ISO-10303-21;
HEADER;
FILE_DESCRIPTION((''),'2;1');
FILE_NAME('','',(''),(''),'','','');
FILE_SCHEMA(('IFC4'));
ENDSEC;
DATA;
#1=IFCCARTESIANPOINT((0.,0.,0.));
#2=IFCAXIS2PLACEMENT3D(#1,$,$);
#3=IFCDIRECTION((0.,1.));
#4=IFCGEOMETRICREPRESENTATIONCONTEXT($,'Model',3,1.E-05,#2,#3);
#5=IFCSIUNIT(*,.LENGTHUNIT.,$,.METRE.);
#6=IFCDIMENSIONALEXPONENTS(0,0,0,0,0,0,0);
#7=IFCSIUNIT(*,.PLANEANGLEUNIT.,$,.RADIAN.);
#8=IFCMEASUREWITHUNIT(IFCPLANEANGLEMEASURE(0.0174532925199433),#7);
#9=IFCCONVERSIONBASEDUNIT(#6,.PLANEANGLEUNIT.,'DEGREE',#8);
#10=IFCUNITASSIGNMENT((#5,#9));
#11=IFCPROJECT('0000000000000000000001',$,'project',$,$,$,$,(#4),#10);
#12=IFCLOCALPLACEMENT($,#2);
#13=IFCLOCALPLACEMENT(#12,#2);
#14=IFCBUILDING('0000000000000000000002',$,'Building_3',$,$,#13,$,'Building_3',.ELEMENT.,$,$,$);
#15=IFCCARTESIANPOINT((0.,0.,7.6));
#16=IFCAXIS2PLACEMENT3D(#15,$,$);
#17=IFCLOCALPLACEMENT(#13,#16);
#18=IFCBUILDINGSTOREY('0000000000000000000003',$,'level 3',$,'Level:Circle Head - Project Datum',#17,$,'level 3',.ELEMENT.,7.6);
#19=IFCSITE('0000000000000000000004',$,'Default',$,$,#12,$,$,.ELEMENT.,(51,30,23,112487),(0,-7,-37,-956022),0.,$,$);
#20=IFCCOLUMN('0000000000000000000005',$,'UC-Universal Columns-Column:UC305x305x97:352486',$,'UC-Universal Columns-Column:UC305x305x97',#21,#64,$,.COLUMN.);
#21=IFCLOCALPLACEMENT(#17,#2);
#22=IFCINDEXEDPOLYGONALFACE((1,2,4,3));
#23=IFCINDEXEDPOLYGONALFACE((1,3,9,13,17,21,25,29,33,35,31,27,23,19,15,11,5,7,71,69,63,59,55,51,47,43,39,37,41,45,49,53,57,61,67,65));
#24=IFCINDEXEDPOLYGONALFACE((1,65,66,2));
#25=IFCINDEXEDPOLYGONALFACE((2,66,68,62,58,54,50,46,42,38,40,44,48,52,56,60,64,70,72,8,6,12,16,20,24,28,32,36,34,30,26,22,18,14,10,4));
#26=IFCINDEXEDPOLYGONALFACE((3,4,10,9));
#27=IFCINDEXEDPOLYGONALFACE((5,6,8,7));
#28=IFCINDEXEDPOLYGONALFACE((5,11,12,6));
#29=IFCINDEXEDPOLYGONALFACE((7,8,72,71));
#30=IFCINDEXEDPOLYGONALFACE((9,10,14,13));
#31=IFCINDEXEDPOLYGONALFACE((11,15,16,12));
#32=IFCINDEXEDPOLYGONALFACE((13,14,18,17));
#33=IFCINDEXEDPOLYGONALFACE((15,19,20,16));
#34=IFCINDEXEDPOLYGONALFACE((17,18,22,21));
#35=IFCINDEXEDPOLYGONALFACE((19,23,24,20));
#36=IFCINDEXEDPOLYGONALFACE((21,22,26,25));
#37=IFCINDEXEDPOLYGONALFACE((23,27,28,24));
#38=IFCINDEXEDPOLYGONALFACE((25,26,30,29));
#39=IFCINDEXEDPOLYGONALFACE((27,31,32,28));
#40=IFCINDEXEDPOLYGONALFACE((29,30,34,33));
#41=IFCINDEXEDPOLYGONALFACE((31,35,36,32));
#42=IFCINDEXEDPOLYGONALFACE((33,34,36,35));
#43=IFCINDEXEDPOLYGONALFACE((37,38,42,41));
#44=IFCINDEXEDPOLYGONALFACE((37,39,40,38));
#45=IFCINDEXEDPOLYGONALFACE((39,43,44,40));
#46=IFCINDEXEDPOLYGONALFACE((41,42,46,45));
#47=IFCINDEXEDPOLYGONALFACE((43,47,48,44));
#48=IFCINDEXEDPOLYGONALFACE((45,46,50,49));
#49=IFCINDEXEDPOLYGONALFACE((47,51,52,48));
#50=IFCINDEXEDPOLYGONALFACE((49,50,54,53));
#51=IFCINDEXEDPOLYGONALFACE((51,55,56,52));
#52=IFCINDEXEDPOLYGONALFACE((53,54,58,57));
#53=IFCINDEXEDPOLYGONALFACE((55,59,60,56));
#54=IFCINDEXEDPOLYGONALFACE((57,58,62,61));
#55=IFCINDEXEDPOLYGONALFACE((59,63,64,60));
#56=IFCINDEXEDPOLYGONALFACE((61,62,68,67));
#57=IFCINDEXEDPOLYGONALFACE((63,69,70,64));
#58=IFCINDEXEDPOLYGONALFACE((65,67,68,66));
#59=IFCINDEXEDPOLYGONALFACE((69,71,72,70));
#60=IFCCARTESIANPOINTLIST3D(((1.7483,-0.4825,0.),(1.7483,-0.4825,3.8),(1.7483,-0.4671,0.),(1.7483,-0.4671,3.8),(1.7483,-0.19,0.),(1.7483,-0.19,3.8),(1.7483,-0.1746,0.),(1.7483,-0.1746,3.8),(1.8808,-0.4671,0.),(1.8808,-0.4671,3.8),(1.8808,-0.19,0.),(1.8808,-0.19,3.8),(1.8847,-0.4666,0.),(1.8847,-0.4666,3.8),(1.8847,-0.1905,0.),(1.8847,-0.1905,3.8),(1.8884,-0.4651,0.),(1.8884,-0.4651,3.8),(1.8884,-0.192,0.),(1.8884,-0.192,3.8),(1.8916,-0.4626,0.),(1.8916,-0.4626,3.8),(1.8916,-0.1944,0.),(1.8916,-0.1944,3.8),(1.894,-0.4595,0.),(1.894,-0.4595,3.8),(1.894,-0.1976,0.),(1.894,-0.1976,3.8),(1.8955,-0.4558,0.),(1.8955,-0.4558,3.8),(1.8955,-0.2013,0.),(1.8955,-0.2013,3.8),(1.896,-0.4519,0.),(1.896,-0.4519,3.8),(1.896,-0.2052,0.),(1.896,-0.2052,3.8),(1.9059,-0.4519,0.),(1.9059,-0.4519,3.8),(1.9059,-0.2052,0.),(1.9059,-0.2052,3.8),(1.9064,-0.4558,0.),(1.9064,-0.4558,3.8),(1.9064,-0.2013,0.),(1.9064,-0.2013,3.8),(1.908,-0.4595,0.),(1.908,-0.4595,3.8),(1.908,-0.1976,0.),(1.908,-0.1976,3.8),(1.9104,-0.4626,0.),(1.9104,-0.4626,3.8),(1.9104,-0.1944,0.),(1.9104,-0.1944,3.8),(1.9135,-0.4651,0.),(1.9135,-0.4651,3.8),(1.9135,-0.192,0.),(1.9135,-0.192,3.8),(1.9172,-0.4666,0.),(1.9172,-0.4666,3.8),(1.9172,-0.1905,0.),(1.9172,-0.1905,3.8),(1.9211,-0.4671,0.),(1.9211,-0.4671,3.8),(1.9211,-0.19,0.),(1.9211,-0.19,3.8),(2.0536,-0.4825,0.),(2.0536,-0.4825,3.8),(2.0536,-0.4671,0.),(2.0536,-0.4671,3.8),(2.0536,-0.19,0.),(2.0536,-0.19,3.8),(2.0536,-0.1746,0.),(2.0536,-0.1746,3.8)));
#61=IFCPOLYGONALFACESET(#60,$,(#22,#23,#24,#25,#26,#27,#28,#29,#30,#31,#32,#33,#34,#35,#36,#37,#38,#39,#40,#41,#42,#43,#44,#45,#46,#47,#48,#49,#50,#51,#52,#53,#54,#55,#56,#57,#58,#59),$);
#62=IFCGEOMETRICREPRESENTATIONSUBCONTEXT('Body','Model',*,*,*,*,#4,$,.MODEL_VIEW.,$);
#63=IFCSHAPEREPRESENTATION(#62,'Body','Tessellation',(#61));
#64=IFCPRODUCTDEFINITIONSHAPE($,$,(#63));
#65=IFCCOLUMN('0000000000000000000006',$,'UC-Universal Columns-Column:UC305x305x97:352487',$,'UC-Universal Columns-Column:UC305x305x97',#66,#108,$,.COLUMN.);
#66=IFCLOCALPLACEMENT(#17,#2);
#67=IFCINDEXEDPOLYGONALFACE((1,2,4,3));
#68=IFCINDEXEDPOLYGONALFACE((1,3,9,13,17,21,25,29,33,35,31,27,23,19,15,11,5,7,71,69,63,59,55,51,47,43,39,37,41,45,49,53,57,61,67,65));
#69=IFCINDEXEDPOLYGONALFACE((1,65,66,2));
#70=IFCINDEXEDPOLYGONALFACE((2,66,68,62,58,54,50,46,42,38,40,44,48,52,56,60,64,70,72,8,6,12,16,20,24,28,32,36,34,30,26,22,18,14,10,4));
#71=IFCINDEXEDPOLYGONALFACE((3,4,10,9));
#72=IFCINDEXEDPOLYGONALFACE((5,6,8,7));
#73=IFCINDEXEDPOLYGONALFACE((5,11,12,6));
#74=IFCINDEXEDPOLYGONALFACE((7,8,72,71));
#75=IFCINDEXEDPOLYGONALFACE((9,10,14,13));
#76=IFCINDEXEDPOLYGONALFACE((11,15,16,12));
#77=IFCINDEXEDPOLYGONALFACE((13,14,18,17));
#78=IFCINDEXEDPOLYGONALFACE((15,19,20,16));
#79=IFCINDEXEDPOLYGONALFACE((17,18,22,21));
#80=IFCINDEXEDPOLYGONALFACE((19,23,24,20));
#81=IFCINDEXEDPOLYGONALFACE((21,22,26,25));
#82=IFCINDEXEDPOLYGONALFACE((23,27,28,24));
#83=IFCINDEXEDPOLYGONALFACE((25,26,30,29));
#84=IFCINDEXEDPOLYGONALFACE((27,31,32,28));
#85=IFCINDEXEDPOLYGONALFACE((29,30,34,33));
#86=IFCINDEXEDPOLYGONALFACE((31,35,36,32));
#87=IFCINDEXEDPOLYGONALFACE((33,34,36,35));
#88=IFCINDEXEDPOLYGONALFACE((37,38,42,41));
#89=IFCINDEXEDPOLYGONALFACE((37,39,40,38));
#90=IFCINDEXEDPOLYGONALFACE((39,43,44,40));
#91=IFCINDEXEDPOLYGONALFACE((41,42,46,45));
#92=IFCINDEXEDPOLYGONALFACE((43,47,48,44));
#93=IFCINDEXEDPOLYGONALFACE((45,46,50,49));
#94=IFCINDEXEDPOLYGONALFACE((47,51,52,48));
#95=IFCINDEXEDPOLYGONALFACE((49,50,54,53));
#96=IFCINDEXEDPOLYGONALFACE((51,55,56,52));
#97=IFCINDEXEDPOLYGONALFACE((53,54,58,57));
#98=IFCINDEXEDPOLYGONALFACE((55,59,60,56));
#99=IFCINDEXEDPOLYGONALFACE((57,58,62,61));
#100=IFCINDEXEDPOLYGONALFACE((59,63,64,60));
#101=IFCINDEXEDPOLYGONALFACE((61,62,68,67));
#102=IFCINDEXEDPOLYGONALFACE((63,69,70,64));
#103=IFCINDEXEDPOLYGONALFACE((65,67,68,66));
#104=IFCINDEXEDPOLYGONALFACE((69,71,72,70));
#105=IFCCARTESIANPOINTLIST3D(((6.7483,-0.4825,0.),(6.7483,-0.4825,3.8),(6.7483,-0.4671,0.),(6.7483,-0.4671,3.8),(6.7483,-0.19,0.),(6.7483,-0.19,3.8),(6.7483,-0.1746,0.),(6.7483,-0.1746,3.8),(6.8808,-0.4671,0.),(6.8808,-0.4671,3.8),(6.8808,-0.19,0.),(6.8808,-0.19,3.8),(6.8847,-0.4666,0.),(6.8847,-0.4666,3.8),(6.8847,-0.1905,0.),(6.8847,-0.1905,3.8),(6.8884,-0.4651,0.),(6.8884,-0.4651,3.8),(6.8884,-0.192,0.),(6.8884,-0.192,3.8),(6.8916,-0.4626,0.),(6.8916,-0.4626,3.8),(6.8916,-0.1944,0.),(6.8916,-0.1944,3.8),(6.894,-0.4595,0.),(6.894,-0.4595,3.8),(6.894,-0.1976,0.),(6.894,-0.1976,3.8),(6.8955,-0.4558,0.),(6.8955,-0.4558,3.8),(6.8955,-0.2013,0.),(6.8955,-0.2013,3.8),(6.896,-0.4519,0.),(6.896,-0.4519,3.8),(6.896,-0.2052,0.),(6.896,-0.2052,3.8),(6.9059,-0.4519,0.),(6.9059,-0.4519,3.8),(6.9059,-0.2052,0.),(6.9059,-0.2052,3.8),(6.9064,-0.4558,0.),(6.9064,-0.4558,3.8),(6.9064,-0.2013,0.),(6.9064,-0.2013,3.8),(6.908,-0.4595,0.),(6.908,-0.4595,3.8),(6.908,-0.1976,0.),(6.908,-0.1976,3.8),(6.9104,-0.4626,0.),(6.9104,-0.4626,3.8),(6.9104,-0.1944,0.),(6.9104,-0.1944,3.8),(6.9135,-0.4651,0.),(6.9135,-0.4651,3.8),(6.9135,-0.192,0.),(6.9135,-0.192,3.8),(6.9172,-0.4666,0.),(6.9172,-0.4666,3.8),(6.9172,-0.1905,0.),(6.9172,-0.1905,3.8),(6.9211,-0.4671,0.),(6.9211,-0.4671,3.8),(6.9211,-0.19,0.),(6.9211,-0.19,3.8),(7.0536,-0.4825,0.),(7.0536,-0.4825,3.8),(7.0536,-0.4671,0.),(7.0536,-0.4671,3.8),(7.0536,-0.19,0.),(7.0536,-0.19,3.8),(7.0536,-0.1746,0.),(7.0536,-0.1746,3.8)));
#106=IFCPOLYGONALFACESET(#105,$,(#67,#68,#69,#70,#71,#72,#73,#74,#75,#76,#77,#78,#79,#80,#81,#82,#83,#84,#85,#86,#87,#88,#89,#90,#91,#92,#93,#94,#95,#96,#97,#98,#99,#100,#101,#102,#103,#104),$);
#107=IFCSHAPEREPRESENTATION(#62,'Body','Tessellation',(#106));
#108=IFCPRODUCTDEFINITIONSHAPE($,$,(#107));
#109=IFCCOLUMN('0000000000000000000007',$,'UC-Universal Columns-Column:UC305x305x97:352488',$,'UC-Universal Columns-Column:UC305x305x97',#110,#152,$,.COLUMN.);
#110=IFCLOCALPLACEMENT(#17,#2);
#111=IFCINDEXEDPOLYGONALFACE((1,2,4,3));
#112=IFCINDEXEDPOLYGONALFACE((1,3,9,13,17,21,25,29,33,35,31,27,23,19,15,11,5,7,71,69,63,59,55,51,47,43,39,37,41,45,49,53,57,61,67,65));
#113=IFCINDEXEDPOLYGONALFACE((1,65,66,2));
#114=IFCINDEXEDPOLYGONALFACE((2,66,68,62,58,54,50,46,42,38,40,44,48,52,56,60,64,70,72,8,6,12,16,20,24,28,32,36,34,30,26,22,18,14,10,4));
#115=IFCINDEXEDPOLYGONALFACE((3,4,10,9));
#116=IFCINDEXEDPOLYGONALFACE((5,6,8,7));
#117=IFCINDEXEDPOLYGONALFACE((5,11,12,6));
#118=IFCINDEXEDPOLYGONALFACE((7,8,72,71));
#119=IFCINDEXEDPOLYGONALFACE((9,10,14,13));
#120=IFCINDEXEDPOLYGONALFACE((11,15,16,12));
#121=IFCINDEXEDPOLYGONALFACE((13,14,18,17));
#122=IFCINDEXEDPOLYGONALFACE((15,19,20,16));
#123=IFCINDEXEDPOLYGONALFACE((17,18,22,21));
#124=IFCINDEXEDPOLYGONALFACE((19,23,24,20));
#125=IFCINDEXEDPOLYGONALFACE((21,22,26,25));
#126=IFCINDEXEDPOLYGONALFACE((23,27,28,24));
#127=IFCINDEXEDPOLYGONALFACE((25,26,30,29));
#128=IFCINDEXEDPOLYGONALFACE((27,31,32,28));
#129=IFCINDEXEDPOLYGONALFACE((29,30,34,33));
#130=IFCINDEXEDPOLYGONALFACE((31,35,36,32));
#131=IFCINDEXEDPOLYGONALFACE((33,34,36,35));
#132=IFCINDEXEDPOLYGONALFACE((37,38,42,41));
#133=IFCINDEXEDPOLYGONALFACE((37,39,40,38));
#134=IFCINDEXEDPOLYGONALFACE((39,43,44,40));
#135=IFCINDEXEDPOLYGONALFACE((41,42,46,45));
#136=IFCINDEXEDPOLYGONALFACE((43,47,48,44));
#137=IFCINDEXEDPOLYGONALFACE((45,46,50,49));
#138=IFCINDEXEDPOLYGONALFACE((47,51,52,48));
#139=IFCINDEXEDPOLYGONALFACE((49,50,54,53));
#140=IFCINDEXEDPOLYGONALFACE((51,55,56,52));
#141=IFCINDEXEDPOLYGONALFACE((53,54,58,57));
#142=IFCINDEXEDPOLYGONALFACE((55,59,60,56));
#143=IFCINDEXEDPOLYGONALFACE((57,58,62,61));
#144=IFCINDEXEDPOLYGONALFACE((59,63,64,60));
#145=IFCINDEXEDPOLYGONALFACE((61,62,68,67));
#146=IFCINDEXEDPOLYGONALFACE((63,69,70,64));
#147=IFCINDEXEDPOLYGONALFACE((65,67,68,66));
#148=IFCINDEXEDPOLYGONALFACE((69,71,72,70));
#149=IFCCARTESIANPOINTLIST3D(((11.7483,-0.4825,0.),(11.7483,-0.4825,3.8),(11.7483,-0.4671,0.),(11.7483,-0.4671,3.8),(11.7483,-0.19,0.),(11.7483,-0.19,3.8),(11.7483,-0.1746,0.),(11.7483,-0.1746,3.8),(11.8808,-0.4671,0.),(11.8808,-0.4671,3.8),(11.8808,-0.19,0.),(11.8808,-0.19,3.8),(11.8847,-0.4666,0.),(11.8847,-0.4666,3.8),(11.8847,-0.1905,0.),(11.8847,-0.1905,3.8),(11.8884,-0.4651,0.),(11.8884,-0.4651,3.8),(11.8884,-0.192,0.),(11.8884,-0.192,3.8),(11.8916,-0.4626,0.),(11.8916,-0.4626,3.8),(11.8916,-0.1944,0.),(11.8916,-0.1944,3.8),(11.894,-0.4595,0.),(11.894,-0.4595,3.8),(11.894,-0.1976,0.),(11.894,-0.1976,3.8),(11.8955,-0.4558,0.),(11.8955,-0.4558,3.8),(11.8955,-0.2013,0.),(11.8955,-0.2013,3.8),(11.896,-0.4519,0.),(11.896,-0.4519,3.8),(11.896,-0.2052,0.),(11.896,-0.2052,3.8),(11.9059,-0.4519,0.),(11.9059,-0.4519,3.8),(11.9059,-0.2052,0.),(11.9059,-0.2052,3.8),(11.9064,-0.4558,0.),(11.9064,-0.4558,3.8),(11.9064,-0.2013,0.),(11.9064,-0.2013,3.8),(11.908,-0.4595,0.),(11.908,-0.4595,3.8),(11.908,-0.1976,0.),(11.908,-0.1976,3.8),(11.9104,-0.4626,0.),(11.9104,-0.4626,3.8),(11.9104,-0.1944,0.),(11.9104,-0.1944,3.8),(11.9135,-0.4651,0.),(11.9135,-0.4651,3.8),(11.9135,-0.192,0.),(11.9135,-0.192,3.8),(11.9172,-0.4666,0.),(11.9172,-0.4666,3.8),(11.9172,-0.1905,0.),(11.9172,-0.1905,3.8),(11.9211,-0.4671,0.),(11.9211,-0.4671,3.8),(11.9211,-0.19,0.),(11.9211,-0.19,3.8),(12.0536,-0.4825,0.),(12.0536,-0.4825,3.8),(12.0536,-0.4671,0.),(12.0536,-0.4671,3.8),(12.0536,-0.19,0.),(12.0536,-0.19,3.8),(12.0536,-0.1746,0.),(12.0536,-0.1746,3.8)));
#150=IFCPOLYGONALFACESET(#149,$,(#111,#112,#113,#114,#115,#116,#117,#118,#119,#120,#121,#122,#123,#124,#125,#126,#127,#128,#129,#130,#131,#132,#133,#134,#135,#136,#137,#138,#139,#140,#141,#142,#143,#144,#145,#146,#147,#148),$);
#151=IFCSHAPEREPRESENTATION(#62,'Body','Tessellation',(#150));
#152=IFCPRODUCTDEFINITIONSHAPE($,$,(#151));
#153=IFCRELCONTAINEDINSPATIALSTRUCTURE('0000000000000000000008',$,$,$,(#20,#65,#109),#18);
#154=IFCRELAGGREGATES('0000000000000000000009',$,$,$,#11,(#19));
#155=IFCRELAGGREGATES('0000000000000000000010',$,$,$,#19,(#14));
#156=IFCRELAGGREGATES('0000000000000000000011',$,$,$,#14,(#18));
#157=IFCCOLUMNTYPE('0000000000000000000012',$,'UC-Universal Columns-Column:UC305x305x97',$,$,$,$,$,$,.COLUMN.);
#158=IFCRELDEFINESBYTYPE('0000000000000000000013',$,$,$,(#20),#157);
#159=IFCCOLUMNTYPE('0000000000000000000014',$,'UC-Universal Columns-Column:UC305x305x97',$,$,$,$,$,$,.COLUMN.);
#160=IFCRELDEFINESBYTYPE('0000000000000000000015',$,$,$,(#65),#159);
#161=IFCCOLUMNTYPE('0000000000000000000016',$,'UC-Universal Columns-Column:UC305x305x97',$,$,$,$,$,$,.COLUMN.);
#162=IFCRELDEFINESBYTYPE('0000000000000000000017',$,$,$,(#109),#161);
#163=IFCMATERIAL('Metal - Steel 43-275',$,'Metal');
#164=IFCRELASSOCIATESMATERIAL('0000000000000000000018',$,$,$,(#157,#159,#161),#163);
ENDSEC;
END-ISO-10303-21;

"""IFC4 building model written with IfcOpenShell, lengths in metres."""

from ifc_helpers import new_model, entity, si_unit, converted_unit, direction, frame, frame_2d, origin, place, context, subcontext, project, spatial, i_section, extrude, source, transform, mapped, material, material_profile, profile_set, type_object, type_shapes, element, save


model = new_model("IFC4")

# Units and contexts
model_context = context("Model", 3, precision=1e-05, world=origin(), true_north=direction((0.0, 1.0)))
body_context = subcontext(model_context, "Body", "Model", "MODEL_VIEW")
ifc_project = project(units=[si_unit("LENGTHUNIT", "METRE"), converted_unit("PLANEANGLEUNIT", "DEGREE", entity("IfcPlaneAngleMeasure", 0.0174532925199433), si_unit("PLANEANGLEUNIT", "RADIAN"), dimensions=[0, 0, 0, 0, 0, 0, 0])], contexts=[model_context])

# Site, building, storey
site_placement = place(None, origin())
site = spatial("IfcSite", under=ifc_project, at=site_placement, Name="Default", CompositionType="ELEMENT", RefLatitude=(51, 30, 23, 112487), RefLongitude=(0, -7, -37, -956022), RefElevation=0.0)
building_placement = place(site_placement, origin())
building = spatial("IfcBuilding", under=site, at=building_placement, Name="Building_3", LongName="Building_3", CompositionType="ELEMENT")
storey_placement = place(building_placement, frame((0.0, 0.0, 7.6)))
storey = spatial("IfcBuildingStorey", under=building, at=storey_placement, Name="level 3", ObjectType="Level:Circle Head - Project Datum", LongName="level 3", CompositionType="ELEMENT", Elevation=7.6)

# Columns
ifc_material_1 = material(Name="Metal - Steel 43-275", Category="Metal")
ifc_material_profile_1 = material_profile(ifc_material_1, i_section(OverallWidth=0.3053, OverallDepth=0.3079, WebThickness=0.0099, FlangeThickness=0.0154, FilletRadius=0.0152, at=frame_2d((0.0, 0.0), x_axis=(1.0, 0.0))), Name="UC305x305x97")
ifc_profile_set_1 = profile_set([ifc_material_profile_1], Name="UC305x305x97")
column_type_1 = type_object("IfcColumnType", Name="UC-Universal Columns-Column:UC305x305x97", PredefinedType="COLUMN", material=ifc_profile_set_1)
shared_shape_1 = source(origin(), body_context, "Body", "SweptSolid", [
    extrude(i_section(OverallWidth=0.3053, OverallDepth=0.3079, WebThickness=0.0099, FlangeThickness=0.0154, FilletRadius=0.0152, at=frame_2d((0.0, 0.0), x_axis=(1.0, 0.0))), frame((1.901, -0.3285, 7.6), z_axis=(0.0, 0.0, 1.0), x_axis=(-1.0, 0.0, 0.0)), (0.0, 0.0, 1.0), 3.8),
])
type_shapes(column_type_1, [shared_shape_1])
column_1_placement = place(storey_placement, frame((0.0, 0.0, -7.6)))
element("IfcColumn", 1, at=column_1_placement, inside=storey, type_object=column_type_1, Name="UC-Universal Columns-Column:UC305x305x97:352486", ObjectType="UC-Universal Columns-Column:UC305x305x97", PredefinedType="COLUMN", context=body_context, shape_type="MappedRepresentation", body=[
    mapped(shared_shape_1, transform((0.0, 0.0, 0.0), scale=1.0)),
])
column_type_2 = type_object("IfcColumnType", Name="UC-Universal Columns-Column:UC305x305x97", PredefinedType="COLUMN", material=ifc_profile_set_1)
shared_shape_2 = source(origin(), body_context, "Body", "SweptSolid", [
    extrude(i_section(OverallWidth=0.3053, OverallDepth=0.3079, WebThickness=0.0099, FlangeThickness=0.0154, FilletRadius=0.0152, at=frame_2d((0.0, 0.0), x_axis=(1.0, 0.0))), frame((6.901, -0.3285, 7.6), z_axis=(0.0, 0.0, 1.0), x_axis=(-1.0, 0.0, 0.0)), (0.0, 0.0, 1.0), 3.8),
])
type_shapes(column_type_2, [shared_shape_2])
column_2_placement = place(storey_placement, frame((0.0, 0.0, -7.6)))
element("IfcColumn", 2, at=column_2_placement, inside=storey, type_object=column_type_2, Name="UC-Universal Columns-Column:UC305x305x97:352487", ObjectType="UC-Universal Columns-Column:UC305x305x97", PredefinedType="COLUMN", context=body_context, shape_type="MappedRepresentation", body=[
    mapped(shared_shape_2, transform((0.0, 0.0, 0.0), scale=1.0)),
])
column_type_3 = type_object("IfcColumnType", Name="UC-Universal Columns-Column:UC305x305x97", PredefinedType="COLUMN", material=ifc_profile_set_1)
shared_shape_3 = source(origin(), body_context, "Body", "SweptSolid", [
    extrude(i_section(OverallWidth=0.3053, OverallDepth=0.3079, WebThickness=0.0099, FlangeThickness=0.0154, FilletRadius=0.0152, at=frame_2d((0.0, 0.0), x_axis=(1.0, 0.0))), frame((11.901, -0.3285, 7.6), z_axis=(0.0, 0.0, 1.0), x_axis=(-1.0, 0.0, 0.0)), (0.0, 0.0, 1.0), 3.8),
])
type_shapes(column_type_3, [shared_shape_3])
column_3_placement = place(storey_placement, frame((0.0, 0.0, -7.6)))
element("IfcColumn", 3, at=column_3_placement, inside=storey, type_object=column_type_3, Name="UC-Universal Columns-Column:UC305x305x97:352488", ObjectType="UC-Universal Columns-Column:UC305x305x97", PredefinedType="COLUMN", context=body_context, shape_type="MappedRepresentation", body=[
    mapped(shared_shape_3, transform((0.0, 0.0, 0.0), scale=1.0)),
])

save(model, "model.ifc")
